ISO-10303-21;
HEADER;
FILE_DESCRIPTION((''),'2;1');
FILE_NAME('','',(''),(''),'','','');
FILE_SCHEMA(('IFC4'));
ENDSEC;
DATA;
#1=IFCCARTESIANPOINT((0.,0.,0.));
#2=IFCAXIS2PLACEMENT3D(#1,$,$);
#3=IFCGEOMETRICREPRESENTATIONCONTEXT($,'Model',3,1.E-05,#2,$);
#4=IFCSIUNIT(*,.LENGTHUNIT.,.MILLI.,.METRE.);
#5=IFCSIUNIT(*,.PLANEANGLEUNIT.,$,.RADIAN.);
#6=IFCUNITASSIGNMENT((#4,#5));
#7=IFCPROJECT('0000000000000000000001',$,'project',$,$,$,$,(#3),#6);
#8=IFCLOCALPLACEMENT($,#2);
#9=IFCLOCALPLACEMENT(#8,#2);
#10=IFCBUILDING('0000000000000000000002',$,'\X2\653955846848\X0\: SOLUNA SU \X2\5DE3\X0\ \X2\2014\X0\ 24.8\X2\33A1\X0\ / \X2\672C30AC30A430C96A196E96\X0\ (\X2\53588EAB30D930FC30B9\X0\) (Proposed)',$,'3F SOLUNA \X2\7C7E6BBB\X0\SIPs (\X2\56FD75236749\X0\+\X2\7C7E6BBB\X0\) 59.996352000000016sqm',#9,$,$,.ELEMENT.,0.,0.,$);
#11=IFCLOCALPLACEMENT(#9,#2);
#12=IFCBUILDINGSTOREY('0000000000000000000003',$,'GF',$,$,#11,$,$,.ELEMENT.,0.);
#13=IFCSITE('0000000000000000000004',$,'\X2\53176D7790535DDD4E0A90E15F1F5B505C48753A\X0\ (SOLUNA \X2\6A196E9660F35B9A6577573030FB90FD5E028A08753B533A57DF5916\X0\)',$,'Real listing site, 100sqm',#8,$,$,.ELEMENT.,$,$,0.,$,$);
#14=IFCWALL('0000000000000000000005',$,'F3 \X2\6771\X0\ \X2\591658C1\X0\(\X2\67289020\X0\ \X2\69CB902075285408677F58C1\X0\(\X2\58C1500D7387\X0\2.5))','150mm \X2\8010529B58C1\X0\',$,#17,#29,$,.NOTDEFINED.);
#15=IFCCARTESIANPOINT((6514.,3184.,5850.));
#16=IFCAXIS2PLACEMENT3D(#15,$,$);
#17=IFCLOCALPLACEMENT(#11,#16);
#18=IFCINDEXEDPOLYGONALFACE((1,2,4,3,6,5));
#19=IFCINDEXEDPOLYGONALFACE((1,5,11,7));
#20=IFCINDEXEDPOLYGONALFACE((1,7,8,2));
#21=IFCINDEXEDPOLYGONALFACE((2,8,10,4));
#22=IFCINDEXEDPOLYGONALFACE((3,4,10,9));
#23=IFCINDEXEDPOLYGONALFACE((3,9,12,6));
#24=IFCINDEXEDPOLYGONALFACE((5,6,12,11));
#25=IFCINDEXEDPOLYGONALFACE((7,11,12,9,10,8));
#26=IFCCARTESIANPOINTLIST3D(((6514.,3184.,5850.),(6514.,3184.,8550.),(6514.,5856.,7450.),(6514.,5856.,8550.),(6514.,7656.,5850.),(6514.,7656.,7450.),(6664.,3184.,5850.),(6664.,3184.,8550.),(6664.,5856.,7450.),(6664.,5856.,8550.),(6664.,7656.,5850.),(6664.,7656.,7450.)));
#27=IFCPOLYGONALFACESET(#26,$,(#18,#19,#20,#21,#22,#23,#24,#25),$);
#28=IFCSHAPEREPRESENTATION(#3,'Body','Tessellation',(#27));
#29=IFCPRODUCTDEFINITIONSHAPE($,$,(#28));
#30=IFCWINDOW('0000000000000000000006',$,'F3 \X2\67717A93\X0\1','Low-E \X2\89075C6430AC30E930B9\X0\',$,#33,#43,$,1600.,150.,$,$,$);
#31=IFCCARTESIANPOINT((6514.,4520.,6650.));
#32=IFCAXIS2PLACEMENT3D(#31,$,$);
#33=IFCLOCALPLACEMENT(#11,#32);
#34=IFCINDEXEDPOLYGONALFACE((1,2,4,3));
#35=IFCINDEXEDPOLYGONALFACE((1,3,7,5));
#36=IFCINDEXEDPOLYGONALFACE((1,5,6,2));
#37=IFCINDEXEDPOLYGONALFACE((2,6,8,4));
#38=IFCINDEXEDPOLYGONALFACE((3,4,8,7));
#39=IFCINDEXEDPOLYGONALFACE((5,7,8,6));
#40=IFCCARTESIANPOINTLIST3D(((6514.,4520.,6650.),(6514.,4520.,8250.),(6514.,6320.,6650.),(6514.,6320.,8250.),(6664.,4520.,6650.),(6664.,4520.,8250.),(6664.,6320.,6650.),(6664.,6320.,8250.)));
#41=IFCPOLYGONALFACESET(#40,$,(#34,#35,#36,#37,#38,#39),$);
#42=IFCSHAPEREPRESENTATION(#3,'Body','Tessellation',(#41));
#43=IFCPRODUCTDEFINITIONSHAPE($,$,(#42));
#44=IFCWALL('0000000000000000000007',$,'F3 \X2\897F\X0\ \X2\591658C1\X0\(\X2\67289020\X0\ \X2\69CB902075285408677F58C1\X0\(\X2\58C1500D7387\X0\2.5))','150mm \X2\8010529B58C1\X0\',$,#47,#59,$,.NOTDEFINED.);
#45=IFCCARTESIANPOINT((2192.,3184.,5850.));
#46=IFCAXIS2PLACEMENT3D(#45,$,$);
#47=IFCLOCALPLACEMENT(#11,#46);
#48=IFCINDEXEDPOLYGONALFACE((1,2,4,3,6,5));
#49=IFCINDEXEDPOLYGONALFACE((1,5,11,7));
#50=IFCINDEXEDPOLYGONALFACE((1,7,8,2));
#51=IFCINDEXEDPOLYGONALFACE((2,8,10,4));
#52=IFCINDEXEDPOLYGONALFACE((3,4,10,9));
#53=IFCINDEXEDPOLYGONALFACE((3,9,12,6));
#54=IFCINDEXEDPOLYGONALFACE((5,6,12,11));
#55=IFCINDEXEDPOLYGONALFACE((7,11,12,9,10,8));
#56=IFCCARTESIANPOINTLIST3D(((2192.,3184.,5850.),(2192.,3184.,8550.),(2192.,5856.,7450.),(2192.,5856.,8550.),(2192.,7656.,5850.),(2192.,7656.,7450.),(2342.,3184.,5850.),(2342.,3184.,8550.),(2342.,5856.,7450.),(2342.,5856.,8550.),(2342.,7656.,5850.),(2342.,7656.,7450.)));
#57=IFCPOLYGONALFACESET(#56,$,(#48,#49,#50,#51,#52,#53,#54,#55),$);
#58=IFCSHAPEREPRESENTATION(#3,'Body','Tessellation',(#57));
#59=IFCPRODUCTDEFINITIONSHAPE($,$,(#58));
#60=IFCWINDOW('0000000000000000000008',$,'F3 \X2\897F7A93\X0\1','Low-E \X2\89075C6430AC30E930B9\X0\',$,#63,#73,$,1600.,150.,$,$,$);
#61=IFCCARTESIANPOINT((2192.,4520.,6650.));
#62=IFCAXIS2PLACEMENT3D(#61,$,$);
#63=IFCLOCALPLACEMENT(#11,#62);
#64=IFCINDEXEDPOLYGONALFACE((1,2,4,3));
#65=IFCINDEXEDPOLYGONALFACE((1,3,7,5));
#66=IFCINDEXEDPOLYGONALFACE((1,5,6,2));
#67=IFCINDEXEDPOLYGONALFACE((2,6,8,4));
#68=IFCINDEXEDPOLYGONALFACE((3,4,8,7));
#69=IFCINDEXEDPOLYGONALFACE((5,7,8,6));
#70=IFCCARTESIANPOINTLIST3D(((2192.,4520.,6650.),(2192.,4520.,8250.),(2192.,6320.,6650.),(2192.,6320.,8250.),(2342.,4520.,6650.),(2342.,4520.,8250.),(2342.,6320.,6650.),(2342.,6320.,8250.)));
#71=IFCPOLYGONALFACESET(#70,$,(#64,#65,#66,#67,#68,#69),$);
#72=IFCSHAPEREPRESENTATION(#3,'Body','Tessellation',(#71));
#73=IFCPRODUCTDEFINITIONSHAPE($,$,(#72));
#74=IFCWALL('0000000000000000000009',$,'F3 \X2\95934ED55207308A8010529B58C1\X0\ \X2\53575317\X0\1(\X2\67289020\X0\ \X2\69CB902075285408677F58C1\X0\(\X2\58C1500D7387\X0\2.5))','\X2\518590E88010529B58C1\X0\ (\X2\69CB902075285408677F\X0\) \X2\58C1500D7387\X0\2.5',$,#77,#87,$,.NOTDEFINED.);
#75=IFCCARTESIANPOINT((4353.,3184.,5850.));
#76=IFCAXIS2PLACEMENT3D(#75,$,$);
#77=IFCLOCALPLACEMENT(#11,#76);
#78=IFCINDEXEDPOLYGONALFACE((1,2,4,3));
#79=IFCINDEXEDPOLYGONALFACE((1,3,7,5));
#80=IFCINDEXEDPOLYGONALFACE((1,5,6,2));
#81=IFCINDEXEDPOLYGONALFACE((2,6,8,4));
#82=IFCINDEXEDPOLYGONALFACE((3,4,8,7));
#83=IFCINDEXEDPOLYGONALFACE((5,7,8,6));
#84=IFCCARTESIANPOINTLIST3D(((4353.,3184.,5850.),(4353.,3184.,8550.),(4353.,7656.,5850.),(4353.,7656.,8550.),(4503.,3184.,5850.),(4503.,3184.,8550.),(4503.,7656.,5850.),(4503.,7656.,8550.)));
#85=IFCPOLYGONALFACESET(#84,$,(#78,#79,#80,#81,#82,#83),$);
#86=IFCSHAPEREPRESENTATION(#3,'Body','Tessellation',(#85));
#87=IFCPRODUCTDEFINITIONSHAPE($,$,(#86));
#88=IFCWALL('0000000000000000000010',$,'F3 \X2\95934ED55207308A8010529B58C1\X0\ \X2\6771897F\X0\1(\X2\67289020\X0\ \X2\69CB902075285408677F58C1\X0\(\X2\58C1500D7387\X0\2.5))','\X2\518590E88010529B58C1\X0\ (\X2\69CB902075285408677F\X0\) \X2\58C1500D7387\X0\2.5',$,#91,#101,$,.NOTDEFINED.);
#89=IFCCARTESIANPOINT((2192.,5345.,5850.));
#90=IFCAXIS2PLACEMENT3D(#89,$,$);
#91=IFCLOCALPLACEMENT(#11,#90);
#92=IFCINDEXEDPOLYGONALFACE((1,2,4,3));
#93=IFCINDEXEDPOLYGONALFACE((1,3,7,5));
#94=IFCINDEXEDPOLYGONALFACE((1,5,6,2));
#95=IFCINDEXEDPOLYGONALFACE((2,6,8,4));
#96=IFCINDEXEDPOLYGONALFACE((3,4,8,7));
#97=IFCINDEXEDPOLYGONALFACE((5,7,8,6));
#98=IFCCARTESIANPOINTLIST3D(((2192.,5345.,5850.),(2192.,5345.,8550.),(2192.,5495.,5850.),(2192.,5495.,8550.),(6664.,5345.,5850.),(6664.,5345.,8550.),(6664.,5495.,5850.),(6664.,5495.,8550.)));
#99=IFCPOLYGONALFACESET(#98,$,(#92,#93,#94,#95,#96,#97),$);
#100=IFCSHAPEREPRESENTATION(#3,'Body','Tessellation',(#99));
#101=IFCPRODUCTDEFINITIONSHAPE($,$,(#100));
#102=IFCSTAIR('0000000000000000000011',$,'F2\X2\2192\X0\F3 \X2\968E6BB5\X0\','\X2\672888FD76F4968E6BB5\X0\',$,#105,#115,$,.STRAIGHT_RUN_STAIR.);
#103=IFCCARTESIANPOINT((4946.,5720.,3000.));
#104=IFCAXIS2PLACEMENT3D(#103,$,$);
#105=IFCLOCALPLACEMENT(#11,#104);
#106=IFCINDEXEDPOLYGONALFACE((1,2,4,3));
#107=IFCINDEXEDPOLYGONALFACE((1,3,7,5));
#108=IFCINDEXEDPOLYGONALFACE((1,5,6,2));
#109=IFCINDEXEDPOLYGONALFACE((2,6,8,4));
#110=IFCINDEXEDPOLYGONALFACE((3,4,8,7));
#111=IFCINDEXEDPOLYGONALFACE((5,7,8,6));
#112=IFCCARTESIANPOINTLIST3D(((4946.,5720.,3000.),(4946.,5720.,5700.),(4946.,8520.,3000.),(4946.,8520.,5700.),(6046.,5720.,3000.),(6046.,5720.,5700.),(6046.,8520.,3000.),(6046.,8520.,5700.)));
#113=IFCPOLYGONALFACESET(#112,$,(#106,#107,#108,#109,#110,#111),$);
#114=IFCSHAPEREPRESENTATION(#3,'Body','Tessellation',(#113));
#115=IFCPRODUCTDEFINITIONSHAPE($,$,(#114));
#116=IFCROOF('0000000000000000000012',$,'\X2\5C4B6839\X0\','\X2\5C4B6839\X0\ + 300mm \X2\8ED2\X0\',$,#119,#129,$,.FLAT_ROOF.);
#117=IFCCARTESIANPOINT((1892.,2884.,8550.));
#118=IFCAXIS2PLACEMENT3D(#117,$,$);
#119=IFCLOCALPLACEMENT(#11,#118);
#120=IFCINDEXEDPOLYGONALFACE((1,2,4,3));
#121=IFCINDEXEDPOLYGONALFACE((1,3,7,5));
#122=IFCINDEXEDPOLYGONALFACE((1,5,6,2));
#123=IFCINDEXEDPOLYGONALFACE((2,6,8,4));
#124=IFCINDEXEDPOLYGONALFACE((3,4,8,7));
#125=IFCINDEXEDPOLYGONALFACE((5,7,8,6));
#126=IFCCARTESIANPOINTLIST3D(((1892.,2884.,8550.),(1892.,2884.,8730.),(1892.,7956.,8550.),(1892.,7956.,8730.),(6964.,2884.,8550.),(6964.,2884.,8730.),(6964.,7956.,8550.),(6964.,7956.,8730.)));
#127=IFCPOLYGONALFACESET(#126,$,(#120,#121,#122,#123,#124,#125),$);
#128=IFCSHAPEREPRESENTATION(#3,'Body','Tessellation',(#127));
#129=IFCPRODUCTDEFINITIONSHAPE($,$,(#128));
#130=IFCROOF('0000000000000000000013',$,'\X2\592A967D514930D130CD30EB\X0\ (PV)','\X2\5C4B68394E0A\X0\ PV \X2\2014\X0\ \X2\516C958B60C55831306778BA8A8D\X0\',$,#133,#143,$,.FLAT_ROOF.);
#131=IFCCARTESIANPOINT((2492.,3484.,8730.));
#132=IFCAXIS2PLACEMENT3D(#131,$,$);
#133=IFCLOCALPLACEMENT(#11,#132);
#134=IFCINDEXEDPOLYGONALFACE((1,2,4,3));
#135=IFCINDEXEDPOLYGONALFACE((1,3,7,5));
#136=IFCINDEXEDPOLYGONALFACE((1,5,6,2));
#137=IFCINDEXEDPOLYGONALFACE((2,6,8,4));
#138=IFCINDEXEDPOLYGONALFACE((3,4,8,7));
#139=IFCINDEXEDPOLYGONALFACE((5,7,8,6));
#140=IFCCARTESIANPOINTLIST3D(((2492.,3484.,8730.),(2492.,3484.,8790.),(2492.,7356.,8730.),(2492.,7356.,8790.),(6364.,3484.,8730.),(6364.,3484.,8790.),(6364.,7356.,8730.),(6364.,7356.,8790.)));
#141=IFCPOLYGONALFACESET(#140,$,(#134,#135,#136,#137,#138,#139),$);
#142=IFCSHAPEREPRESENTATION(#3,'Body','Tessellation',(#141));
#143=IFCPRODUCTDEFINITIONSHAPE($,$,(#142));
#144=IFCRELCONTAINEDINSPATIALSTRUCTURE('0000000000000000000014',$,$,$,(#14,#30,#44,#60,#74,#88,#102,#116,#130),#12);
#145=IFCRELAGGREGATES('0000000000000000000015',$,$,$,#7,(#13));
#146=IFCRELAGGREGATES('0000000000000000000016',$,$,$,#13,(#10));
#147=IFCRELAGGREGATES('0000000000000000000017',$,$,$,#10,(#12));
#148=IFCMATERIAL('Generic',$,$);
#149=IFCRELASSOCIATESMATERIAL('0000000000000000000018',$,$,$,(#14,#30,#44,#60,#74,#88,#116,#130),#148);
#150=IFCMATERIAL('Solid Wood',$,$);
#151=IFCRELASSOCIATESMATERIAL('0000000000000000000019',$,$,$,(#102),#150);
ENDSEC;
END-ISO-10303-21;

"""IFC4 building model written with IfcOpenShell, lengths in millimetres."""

from ifc_helpers import new_model, si_unit, frame, frame_2d, origin, place, context, project, spatial, rectangle, extrude, material, element, fill, save


model = new_model("IFC4")

# Units and contexts
model_context = context("Model", 3, precision=1e-05, world=origin())
ifc_project = project(units=[si_unit("LENGTHUNIT", "METRE", prefix="MILLI"), si_unit("PLANEANGLEUNIT", "RADIAN")], contexts=[model_context])

# Site, building, storey
site_placement = place(None, origin())
site = spatial("IfcSite", under=ifc_project, at=site_placement, Name="北海道川上郡弟子屈町 (SOLUNA 標準想定敷地・都市計画区域外)", ObjectType="Real listing site, 100sqm", CompositionType="ELEMENT", RefElevation=0.0)
building_placement = place(site_placement, origin())
building = spatial("IfcBuilding", under=site, at=building_placement, Name="改善案: SOLUNA SU 巣 — 24.8㎡ / 本ガイド標準 (単身ベース) (Proposed)", ObjectType="3F SOLUNA 籾殻SIPs (国産杉+籾殻) 59.996352000000016sqm", CompositionType="ELEMENT", ElevationOfRefHeight=0.0, ElevationOfTerrain=0.0)
storey_placement = place(building_placement, origin())
storey = spatial("IfcBuildingStorey", under=building, at=storey_placement, Name="GF", CompositionType="ELEMENT", Elevation=0.0)

# Shared definitions
ifc_material_1 = material(Name="Generic")

# Walls, openings, windows
wall_1_placement = place(storey_placement, frame((6514.0, 3184.0, 5850.0)))
wall_1 = element("IfcWall", 1, at=wall_1_placement, inside=storey, material=ifc_material_1, Name="F3 東 外壁(木造 構造用合板壁(壁倍率2.5))", Description="150mm 耐力壁", PredefinedType="NOTDEFINED", context=model_context, shape_type="SweptSolid", body=[
    extrude(rectangle(XDim=150.0, YDim=4472.0, at=frame_2d((75.0, 2236.0))), frame((6514.0, 3184.0, 5850.0)), (0.0, 0.0, 1.0), 2700.0),
])
opening_1_placement = place(storey_placement, frame((6514.0, 4520.0, 6650.0)))
opening_1 = element("IfcOpeningElement", 2, at=opening_1_placement, cuts=wall_1, PredefinedType="NOTDEFINED", context=model_context, shape_type="SweptSolid", body=[
    extrude(rectangle(XDim=150.0, YDim=1800.0, at=frame_2d((75.0, 900.0))), frame((6514.0, 4520.0, 6650.0)), (0.0, 0.0, 1.0), 1600.0),
])
window_1_placement = place(storey_placement, frame((6514.0, 4520.0, 6650.0)))
window_1 = element("IfcWindow", 3, at=window_1_placement, inside=storey, material=ifc_material_1, Name="F3 東窓1", Description="Low-E 複層ガラス", OverallHeight=1600.0, OverallWidth=150.0, context=model_context, shape_type="SweptSolid", body=[
    extrude(rectangle(XDim=150.0, YDim=1800.0, at=frame_2d((75.0, 900.0))), frame((6514.0, 4520.0, 6650.0)), (0.0, 0.0, 1.0), 1600.0),
])
fill(opening_1, window_1)
wall_2_placement = place(storey_placement, frame((2192.0, 3184.0, 5850.0)))
wall_2 = element("IfcWall", 4, at=wall_2_placement, inside=storey, material=ifc_material_1, Name="F3 西 外壁(木造 構造用合板壁(壁倍率2.5))", Description="150mm 耐力壁", PredefinedType="NOTDEFINED", context=model_context, shape_type="SweptSolid", body=[
    extrude(rectangle(XDim=150.0, YDim=4472.0, at=frame_2d((75.0, 2236.0))), frame((2192.0, 3184.0, 5850.0)), (0.0, 0.0, 1.0), 2700.0),
])
opening_2_placement = place(storey_placement, frame((2192.0, 4520.0, 6650.0)))
opening_2 = element("IfcOpeningElement", 5, at=opening_2_placement, cuts=wall_2, PredefinedType="NOTDEFINED", context=model_context, shape_type="SweptSolid", body=[
    extrude(rectangle(XDim=150.0, YDim=1800.0, at=frame_2d((75.0, 900.0))), frame((2192.0, 4520.0, 6650.0)), (0.0, 0.0, 1.0), 1600.0),
])
window_2_placement = place(storey_placement, frame((2192.0, 4520.0, 6650.0)))
window_2 = element("IfcWindow", 6, at=window_2_placement, inside=storey, material=ifc_material_1, Name="F3 西窓1", Description="Low-E 複層ガラス", OverallHeight=1600.0, OverallWidth=150.0, context=model_context, shape_type="SweptSolid", body=[
    extrude(rectangle(XDim=150.0, YDim=1800.0, at=frame_2d((75.0, 900.0))), frame((2192.0, 4520.0, 6650.0)), (0.0, 0.0, 1.0), 1600.0),
])
fill(opening_2, window_2)

# Walls
wall_3_placement = place(storey_placement, frame((4353.0, 3184.0, 5850.0)))
element("IfcWall", 7, at=wall_3_placement, inside=storey, material=ifc_material_1, Name="F3 間仕切り耐力壁 南北1(木造 構造用合板壁(壁倍率2.5))", Description="内部耐力壁 (構造用合板) 壁倍率2.5", PredefinedType="NOTDEFINED", context=model_context, shape_type="SweptSolid", body=[
    extrude(rectangle(XDim=150.0, YDim=4472.0, at=frame_2d((75.0, 2236.0))), frame((4353.0, 3184.0, 5850.0)), (0.0, 0.0, 1.0), 2700.0),
])
wall_4_placement = place(storey_placement, frame((2192.0, 5345.0, 5850.0)))
element("IfcWall", 8, at=wall_4_placement, inside=storey, material=ifc_material_1, Name="F3 間仕切り耐力壁 東西1(木造 構造用合板壁(壁倍率2.5))", Description="内部耐力壁 (構造用合板) 壁倍率2.5", PredefinedType="NOTDEFINED", context=model_context, shape_type="SweptSolid", body=[
    extrude(rectangle(XDim=4472.0, YDim=150.0, at=frame_2d((2236.0, 75.0))), frame((2192.0, 5345.0, 5850.0)), (0.0, 0.0, 1.0), 2700.0),
])

# Stair
ifc_material_2 = material(Name="Solid Wood")
stair_placement = place(storey_placement, frame((4946.0, 5720.0, 3000.0)))
element("IfcStair", 9, at=stair_placement, inside=storey, material=ifc_material_2, Name="F2→F3 階段", Description="木製直階段", PredefinedType="STRAIGHT_RUN_STAIR", context=model_context, shape_type="SweptSolid", body=[
    extrude(rectangle(XDim=1100.0, YDim=2800.0, at=frame_2d((550.0, 1400.0))), frame((4946.0, 5720.0, 3000.0)), (0.0, 0.0, 1.0), 2700.0),
])

# Roofs
roof_1_placement = place(storey_placement, frame((1892.0, 2884.0, 8550.0)))
element("IfcRoof", 10, at=roof_1_placement, inside=storey, material=ifc_material_1, Name="屋根", Description="屋根 + 300mm 軒", PredefinedType="FLAT_ROOF", context=model_context, shape_type="SweptSolid", body=[
    extrude(rectangle(XDim=5072.0, YDim=5072.0, at=frame_2d((2536.0, 2536.0))), frame((1892.0, 2884.0, 8550.0)), (0.0, 0.0, 1.0), 180.0),
])
roof_2_placement = place(storey_placement, frame((2492.0, 3484.0, 8730.0)))
element("IfcRoof", 11, at=roof_2_placement, inside=storey, material=ifc_material_1, Name="太陽光パネル (PV)", Description="屋根上 PV — 公開情報で確認", PredefinedType="FLAT_ROOF", context=model_context, shape_type="SweptSolid", body=[
    extrude(rectangle(XDim=3872.0, YDim=3872.0, at=frame_2d((1936.0, 1936.0))), frame((2492.0, 3484.0, 8730.0)), (0.0, 0.0, 1.0), 60.0),
])

save(model, "model.ifc")
